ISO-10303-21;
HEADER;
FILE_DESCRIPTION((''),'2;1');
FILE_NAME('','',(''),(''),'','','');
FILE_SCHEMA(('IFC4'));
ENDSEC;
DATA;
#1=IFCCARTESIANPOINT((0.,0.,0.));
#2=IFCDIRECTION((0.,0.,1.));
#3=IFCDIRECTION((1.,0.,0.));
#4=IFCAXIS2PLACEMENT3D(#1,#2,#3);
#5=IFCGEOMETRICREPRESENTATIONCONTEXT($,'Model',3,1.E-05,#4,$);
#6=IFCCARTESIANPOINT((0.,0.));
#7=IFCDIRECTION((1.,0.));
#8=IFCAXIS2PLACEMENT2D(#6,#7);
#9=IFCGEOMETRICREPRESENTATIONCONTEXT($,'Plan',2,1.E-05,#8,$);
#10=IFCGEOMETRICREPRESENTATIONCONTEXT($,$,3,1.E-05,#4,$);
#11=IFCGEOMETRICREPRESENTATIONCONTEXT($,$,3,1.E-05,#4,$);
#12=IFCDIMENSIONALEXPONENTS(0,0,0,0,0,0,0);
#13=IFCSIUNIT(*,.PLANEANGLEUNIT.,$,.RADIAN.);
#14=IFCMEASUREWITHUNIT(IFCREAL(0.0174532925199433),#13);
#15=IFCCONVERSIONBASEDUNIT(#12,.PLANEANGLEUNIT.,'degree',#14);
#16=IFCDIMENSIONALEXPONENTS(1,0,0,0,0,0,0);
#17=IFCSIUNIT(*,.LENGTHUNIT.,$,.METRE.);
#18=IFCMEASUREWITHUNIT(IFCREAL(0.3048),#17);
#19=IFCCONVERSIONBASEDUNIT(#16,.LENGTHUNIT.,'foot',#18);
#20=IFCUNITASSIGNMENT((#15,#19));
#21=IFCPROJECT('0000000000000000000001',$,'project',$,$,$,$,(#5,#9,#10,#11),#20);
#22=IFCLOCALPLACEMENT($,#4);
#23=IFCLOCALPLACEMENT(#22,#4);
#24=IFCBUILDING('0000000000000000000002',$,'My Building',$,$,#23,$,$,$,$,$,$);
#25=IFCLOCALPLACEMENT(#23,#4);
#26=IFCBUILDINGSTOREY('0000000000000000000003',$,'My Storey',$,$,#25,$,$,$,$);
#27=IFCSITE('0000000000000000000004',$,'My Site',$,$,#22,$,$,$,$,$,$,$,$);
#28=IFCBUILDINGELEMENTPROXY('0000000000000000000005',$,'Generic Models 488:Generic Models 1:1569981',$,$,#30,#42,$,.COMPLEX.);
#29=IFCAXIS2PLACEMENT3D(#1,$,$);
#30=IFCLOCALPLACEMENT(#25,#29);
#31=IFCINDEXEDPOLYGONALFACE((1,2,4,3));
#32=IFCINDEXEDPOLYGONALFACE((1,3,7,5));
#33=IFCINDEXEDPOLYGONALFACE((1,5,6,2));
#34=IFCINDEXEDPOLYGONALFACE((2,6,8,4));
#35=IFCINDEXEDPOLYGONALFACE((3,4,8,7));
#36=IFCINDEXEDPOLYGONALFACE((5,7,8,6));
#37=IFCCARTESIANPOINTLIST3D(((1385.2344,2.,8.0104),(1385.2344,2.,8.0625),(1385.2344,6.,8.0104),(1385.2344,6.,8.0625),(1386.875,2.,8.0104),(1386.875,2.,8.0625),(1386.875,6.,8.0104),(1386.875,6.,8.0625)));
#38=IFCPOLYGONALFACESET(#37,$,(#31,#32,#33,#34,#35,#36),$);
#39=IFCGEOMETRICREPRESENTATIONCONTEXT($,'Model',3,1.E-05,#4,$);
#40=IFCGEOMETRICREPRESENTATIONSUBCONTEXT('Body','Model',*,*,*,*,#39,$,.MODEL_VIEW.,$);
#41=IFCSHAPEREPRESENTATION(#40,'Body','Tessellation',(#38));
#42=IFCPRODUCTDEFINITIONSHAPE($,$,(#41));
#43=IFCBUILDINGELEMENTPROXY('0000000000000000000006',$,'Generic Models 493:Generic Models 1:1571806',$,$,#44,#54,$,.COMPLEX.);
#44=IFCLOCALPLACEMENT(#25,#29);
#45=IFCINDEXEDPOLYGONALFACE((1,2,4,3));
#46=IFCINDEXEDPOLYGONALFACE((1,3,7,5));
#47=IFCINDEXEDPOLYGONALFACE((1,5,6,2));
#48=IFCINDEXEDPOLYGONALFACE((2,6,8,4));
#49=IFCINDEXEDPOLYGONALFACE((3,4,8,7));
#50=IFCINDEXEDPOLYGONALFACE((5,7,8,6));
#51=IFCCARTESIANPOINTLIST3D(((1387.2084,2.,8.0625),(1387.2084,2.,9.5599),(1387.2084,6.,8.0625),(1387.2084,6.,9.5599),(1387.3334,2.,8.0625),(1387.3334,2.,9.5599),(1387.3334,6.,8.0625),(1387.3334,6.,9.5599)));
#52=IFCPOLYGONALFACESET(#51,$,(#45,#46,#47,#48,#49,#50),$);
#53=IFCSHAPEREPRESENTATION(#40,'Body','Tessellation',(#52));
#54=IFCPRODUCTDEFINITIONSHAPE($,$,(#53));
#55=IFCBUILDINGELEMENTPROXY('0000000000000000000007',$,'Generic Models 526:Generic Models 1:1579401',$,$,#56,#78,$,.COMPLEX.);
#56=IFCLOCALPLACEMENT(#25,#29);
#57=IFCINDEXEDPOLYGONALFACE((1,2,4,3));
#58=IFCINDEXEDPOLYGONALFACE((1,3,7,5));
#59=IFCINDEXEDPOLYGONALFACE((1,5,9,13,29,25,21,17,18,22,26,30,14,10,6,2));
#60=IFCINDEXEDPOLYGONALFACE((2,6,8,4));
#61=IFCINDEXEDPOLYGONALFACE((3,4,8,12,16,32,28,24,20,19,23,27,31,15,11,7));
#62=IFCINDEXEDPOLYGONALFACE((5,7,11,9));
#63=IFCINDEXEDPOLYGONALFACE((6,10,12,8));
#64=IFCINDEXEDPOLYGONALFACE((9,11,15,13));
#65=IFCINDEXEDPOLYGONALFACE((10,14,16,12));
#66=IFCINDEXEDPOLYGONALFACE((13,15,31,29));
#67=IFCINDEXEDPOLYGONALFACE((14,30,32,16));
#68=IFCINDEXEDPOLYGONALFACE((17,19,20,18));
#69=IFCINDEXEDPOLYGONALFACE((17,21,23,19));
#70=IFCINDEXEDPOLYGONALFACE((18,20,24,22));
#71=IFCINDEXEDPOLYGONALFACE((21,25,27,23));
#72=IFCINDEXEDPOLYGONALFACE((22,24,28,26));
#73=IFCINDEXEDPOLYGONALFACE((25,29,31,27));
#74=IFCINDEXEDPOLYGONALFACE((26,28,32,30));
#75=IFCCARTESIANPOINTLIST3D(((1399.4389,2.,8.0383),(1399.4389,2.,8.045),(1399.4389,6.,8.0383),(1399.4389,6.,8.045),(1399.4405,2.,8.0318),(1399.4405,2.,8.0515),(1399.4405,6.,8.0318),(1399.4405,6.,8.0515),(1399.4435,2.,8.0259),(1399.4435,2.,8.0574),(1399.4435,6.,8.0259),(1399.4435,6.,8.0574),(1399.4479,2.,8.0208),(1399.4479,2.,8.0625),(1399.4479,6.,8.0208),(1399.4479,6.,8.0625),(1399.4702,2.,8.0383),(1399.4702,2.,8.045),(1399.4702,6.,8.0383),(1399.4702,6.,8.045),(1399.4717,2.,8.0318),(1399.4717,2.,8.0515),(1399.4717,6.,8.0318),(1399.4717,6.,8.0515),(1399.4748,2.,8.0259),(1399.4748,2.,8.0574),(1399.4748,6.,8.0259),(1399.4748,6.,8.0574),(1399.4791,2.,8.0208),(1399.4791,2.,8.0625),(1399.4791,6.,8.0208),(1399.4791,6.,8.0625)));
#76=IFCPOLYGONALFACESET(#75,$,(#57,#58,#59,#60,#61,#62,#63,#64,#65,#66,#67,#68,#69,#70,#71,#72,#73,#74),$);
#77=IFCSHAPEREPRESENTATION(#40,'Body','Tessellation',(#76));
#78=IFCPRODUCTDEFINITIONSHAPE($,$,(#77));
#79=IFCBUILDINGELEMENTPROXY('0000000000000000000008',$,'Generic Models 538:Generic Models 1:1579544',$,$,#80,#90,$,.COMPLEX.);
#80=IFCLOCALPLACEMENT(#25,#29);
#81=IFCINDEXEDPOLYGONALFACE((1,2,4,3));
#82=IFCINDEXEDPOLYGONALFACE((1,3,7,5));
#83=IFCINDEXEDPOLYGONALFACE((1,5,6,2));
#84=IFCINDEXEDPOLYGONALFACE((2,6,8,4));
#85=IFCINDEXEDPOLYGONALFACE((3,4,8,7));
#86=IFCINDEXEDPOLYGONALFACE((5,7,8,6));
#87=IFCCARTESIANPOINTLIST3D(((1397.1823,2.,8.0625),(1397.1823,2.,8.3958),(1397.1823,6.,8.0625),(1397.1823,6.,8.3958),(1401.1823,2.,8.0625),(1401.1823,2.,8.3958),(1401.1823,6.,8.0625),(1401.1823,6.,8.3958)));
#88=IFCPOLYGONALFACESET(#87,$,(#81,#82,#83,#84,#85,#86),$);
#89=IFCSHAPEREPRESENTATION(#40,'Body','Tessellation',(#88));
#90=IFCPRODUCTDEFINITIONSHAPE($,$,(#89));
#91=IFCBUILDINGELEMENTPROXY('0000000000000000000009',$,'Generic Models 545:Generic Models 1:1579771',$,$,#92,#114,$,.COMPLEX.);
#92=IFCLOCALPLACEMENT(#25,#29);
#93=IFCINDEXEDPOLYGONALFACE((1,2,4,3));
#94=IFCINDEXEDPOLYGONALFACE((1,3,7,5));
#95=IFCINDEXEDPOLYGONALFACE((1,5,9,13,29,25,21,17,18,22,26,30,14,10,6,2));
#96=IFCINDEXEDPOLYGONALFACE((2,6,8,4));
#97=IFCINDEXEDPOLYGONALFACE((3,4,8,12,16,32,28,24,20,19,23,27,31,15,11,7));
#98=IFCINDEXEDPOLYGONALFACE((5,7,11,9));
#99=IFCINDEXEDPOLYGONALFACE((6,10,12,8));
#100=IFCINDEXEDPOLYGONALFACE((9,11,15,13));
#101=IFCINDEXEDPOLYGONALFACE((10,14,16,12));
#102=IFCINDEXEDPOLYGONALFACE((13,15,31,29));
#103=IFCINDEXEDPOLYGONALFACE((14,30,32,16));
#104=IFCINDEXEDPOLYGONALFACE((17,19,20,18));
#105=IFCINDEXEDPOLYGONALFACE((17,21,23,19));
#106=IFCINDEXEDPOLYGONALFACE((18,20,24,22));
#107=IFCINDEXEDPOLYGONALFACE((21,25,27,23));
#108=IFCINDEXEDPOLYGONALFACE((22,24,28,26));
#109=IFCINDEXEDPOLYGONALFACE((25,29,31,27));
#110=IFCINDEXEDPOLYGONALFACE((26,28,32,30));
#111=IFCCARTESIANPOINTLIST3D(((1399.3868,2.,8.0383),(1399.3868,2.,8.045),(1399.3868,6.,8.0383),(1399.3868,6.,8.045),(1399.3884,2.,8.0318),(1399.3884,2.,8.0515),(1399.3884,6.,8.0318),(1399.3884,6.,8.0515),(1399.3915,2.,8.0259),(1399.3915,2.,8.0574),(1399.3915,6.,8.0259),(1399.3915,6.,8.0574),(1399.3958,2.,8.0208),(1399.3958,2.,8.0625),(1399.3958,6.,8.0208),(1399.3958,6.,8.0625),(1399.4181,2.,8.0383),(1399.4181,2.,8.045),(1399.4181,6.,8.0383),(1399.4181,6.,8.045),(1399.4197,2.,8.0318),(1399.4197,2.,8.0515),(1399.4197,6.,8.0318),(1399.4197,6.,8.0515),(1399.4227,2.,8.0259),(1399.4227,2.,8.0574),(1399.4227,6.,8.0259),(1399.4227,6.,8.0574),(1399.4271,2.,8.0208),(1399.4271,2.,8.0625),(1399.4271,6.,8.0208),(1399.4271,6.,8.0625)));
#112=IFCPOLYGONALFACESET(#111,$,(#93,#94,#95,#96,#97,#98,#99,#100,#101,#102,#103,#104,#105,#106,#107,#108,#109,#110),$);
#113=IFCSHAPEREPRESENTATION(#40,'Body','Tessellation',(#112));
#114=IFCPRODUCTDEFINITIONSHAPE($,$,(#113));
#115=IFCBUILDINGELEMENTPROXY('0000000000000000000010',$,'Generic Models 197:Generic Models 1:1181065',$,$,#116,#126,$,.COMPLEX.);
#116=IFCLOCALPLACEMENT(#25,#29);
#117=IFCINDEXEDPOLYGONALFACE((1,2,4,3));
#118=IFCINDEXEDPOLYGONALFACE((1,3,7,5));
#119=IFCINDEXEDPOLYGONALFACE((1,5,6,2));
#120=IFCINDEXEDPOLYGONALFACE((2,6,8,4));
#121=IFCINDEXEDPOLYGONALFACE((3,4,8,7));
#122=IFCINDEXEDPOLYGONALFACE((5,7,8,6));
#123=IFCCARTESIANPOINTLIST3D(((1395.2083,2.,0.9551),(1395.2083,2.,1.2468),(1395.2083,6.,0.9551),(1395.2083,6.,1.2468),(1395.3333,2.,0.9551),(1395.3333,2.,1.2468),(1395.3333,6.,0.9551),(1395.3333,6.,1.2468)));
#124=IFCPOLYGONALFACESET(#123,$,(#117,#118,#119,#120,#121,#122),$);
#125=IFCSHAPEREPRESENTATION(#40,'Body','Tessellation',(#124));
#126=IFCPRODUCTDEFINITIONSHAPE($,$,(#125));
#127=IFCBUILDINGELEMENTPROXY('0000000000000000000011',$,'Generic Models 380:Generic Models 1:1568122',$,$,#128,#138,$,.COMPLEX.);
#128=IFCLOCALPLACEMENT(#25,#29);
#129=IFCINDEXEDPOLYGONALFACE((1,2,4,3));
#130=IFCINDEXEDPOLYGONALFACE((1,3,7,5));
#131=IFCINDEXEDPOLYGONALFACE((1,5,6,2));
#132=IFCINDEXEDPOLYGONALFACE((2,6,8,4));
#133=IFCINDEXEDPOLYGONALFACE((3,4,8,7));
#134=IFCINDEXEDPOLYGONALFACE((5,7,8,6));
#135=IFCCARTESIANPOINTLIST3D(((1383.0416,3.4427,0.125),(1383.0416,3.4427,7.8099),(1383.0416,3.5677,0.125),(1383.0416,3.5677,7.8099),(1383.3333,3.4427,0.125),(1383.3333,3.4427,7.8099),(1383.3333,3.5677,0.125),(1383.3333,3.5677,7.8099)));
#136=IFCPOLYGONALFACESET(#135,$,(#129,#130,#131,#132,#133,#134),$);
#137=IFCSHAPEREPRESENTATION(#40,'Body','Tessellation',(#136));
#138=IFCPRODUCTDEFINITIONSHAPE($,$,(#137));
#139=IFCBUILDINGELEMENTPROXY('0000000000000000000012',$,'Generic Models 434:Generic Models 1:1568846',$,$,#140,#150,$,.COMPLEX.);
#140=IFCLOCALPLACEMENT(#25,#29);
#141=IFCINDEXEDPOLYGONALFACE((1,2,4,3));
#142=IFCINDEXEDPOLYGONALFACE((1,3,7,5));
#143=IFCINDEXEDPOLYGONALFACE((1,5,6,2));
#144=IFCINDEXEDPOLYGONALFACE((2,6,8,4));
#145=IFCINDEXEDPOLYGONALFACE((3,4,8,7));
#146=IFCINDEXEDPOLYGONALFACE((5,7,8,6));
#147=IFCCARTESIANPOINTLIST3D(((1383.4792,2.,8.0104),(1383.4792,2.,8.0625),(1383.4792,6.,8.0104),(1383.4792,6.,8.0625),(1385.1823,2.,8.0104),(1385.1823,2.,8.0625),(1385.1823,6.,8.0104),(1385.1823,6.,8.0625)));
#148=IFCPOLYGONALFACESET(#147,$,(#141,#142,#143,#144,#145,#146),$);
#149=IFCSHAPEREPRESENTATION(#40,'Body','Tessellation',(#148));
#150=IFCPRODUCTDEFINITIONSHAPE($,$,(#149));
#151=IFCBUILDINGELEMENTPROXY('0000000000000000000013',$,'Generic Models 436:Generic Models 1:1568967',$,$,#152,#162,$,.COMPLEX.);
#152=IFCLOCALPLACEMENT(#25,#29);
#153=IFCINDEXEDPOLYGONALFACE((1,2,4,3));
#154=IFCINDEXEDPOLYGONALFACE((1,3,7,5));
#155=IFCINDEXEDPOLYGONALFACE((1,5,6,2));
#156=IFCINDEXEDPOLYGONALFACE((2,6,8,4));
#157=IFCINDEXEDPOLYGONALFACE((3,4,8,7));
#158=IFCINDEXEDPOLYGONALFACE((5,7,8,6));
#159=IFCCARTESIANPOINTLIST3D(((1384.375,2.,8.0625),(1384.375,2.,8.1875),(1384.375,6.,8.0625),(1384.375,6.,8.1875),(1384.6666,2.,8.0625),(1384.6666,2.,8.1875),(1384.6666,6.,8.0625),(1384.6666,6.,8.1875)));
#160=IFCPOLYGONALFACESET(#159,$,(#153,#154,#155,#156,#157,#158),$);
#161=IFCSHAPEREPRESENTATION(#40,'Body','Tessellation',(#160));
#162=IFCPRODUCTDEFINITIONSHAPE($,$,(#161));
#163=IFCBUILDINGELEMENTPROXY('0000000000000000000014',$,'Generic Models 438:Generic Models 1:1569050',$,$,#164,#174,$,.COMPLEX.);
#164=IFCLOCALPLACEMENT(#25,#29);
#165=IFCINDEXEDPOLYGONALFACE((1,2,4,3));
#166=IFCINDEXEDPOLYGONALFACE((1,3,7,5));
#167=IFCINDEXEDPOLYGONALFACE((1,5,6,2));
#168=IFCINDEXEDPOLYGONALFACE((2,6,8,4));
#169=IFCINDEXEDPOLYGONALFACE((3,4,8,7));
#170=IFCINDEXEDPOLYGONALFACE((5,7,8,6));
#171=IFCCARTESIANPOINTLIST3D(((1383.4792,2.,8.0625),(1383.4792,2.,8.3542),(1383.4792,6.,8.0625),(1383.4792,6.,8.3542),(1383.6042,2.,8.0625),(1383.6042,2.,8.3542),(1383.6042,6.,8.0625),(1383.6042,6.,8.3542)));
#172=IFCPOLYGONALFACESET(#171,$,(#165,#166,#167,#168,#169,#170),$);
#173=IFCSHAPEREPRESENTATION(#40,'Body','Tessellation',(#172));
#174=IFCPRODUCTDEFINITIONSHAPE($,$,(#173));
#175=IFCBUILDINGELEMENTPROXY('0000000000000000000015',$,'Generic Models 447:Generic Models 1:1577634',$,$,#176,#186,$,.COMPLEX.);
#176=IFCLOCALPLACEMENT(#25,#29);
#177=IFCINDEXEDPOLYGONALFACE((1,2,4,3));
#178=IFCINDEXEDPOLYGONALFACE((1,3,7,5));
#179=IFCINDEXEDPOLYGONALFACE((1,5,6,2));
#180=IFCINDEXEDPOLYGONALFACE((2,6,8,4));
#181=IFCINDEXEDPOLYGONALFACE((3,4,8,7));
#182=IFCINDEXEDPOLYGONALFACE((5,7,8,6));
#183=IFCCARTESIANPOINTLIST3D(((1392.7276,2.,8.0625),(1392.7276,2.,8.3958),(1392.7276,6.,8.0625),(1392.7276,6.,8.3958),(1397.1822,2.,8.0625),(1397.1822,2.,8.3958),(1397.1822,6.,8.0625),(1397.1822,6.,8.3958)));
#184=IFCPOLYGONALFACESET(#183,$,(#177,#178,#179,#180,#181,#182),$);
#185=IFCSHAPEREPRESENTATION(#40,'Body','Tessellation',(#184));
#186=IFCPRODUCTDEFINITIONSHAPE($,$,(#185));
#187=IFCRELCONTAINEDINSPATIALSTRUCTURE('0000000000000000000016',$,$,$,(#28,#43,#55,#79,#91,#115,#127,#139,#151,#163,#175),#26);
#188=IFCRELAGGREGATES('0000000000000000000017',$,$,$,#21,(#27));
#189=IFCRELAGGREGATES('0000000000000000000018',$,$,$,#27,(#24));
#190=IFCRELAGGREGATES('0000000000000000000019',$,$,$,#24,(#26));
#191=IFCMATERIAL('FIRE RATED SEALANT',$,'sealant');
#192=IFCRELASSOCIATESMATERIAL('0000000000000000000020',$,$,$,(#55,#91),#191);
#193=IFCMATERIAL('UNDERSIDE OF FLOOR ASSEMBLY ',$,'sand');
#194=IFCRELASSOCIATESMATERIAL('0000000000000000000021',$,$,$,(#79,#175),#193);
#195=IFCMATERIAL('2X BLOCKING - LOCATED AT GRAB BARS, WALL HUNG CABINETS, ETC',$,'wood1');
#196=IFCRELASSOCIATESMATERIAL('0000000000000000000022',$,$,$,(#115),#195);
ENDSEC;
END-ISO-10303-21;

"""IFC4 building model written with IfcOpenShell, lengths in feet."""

from ifc_helpers import new_model, entity, si_unit, converted_unit, frame, origin_with_axes, origin_2d_with_axis, place, context, subcontext, project, spatial, polyline, line, indexed_curve, outline, extrude, material, element, save


model = new_model("IFC4")

# Units and contexts
model_context_1 = context("Model", 3, precision=1e-05, world=origin_with_axes())
plan_context = context("Plan", 2, precision=1e-05, world=origin_2d_with_axis())
model_context_2 = context("Model", 3, precision=1e-05, world=origin_with_axes())
context_of_model_1 = context(None, 3, precision=1e-05, world=origin_with_axes())
context_of_model_2 = context(None, 3, precision=1e-05, world=origin_with_axes())
body_context = subcontext(model_context_2, "Body", "Model", "MODEL_VIEW")
ifc_project = project(units=[converted_unit("PLANEANGLEUNIT", "degree", entity("IfcReal", 0.0174532925199433), si_unit("PLANEANGLEUNIT", "RADIAN"), dimensions=[0, 0, 0, 0, 0, 0, 0]), converted_unit("LENGTHUNIT", "foot", entity("IfcReal", 0.3048), si_unit("LENGTHUNIT", "METRE"), dimensions=[1, 0, 0, 0, 0, 0, 0])], contexts=[model_context_1, plan_context, context_of_model_1, context_of_model_2])

# Site, building, storey
site_placement = place(None, origin_with_axes())
site = spatial("IfcSite", under=ifc_project, at=site_placement, Name="My Site")
building_placement = place(site_placement, origin_with_axes())
building = spatial("IfcBuilding", under=site, at=building_placement, Name="My Building")
storey_placement = place(building_placement, origin_with_axes())
storey = spatial("IfcBuildingStorey", under=building, at=storey_placement, Name="My Storey")

# Building element proxies
proxy_1_placement = place(storey_placement, frame((1385.2344, 6.0, 8.0104), z_axis=(0.0, -1.0, 0.0), x_axis=(0.0, 0.0, 1.0)))
element("IfcBuildingElementProxy", 1, at=proxy_1_placement, inside=storey, Name="Generic Models 488:Generic Models 1:1569981", PredefinedType="COMPLEX", context=body_context, shape_type="SweptSolid", body=[
    extrude(outline(polyline([(-0.026, -0.8203), (0.026, -0.8203), (0.026, 0.8203), (-0.026, 0.8203), (-0.026, -0.8203)])), frame((0.026, -0.8203, 0.0), z_axis=(0.0, 0.0, -1.0), x_axis=(1.0, 0.0, 0.0)), (0.0, 0.0, -1.0), 4.0),
])
proxy_2_placement = place(storey_placement, frame((1387.2084, 6.0, 8.0625), z_axis=(0.0, -1.0, 0.0), x_axis=(0.0, 0.0, 1.0)))
element("IfcBuildingElementProxy", 2, at=proxy_2_placement, inside=storey, Name="Generic Models 493:Generic Models 1:1571806", PredefinedType="COMPLEX", context=body_context, shape_type="SweptSolid", body=[
    extrude(outline(polyline([(-0.7487, -0.0625), (0.7487, -0.0625), (0.7487, 0.0625), (-0.7487, 0.0625), (-0.7487, -0.0625)])), frame((0.7487, -0.0625, 0.0), z_axis=(0.0, 0.0, -1.0), x_axis=(-1.0, 0.0, 0.0)), (0.0, 0.0, -1.0), 4.0),
])
ifc_material_1 = material(Name="FIRE RATED SEALANT", Category="sealant")
proxy_3_placement = place(storey_placement, frame((1399.4389, 6.0, 8.0208), z_axis=(0.0, -1.0, 0.0), x_axis=(0.0, 0.0, 1.0)))
element("IfcBuildingElementProxy", 3, at=proxy_3_placement, inside=storey, material=ifc_material_1, Name="Generic Models 526:Generic Models 1:1579401", PredefinedType="COMPLEX", context=body_context, shape_type="SweptSolid", body=[
    extrude(outline(polyline([(0.0294, 0.0), (0.0074, 0.0221), (0.0007, 0.0216), (-0.0057, 0.0196), (-0.0114, 0.0161), (-0.0161, 0.0114), (-0.0196, 0.0057), (-0.0216, -0.0007), (-0.0221, -0.0073), (0.0, -0.0294), (0.0005, -0.0228), (0.0025, -0.0164), (0.006, -0.0107), (0.0107, -0.006), (0.0164, -0.0025), (0.0228, -0.0005), (0.0294, 0.0)])), frame((0.0208, -0.0194, 0.0), z_axis=(0.0, 0.0, -1.0), x_axis=(-0.707667, -0.706546, 0.0)), (0.0, 0.0, -1.0), 4.0),
])
ifc_material_2 = material(Name="UNDERSIDE OF FLOOR ASSEMBLY ", Category="sand")
proxy_4_placement = place(storey_placement, frame((1397.1823, 6.0, 8.0625), z_axis=(0.0, -1.0, 0.0), x_axis=(0.0, 0.0, 1.0)))
element("IfcBuildingElementProxy", 4, at=proxy_4_placement, inside=storey, material=ifc_material_2, Name="Generic Models 538:Generic Models 1:1579544", PredefinedType="COMPLEX", context=body_context, shape_type="SweptSolid", body=[
    extrude(outline(polyline([(-0.1667, -2.0), (0.1667, -2.0), (0.1667, 2.0), (-0.1667, 2.0), (-0.1667, -2.0)])), frame((0.1667, -2.0, 0.0), z_axis=(0.0, 0.0, -1.0), x_axis=(1.0, 0.0, 0.0)), (0.0, 0.0, -1.0), 4.0),
])
proxy_5_placement = place(storey_placement, frame((1399.3868, 6.0, 8.0208), z_axis=(0.0, -1.0, 0.0), x_axis=(0.0, 0.0, 1.0)))
element("IfcBuildingElementProxy", 5, at=proxy_5_placement, inside=storey, material=ifc_material_1, Name="Generic Models 545:Generic Models 1:1579771", PredefinedType="COMPLEX", context=body_context, shape_type="SweptSolid", body=[
    extrude(outline(polyline([(0.0166, 0.0), (0.0115, 0.0043), (0.0076, 0.0097), (0.005, 0.0159), (0.0039, 0.0224), (0.0045, 0.0291), (-0.0207, 0.0106), (-0.0213, 0.004), (-0.0202, -0.0026), (-0.0176, -0.0088), (-0.0137, -0.0142), (-0.0086, -0.0185), (-0.0026, -0.0215), (0.0039, -0.023), (0.0291, -0.0045), (0.0226, -0.003), (0.0166, 0.0)])), frame((0.0208, -0.0194, 0.0), z_axis=(0.0, 0.0, -1.0), x_axis=(0.591192, -0.806531, 0.0)), (0.0, 0.0, -1.0), 4.0),
])
ifc_material_3 = material(Name="2X BLOCKING - LOCATED AT GRAB BARS, WALL HUNG CABINETS, ETC", Category="wood1")
proxy_6_placement = place(storey_placement, frame((1395.2083, 6.0, 0.9551), z_axis=(0.0, -1.0, 0.0), x_axis=(0.0, 0.0, 1.0)))
element("IfcBuildingElementProxy", 6, at=proxy_6_placement, inside=storey, material=ifc_material_3, Name="Generic Models 197:Generic Models 1:1181065", PredefinedType="COMPLEX", context=body_context, shape_type="SweptSolid", body=[
    extrude(outline(polyline([(-0.0625, -0.1458), (0.0625, -0.1458), (0.0625, 0.1458), (-0.0625, 0.1458), (-0.0625, -0.1458)])), frame((0.1458, -0.0625, 0.0), z_axis=(0.0, 0.0, -1.0), x_axis=(0.0, -1.0, 0.0)), (0.0, 0.0, -1.0), 4.0),
])
proxy_7_placement = place(storey_placement, frame((1383.0416, 7.4427, 0.125), z_axis=(0.0, -1.0, 0.0), x_axis=(1.0, 0.0, 0.0)))
element("IfcBuildingElementProxy", 7, at=proxy_7_placement, inside=storey, Name="Generic Models 380:Generic Models 1:1568122", PredefinedType="COMPLEX", context=body_context, shape_type="SweptSolid", body=[
    extrude(outline(polyline([(-0.1458, -3.8424), (0.1458, -3.8424), (0.1458, 3.8424), (-0.1458, 3.8424), (-0.1458, -3.8424)])), frame((0.1458, 3.8424, 3.875), z_axis=(0.0, 0.0, -1.0), x_axis=(-1.0, 0.0, 0.0)), (0.0, 0.000002, -1.0), 0.125),
])
proxy_8_placement = place(storey_placement, frame((1383.4792, 6.0, 8.0104), z_axis=(0.0, -1.0, 0.0), x_axis=(0.0, 0.0, 1.0)))
element("IfcBuildingElementProxy", 8, at=proxy_8_placement, inside=storey, Name="Generic Models 434:Generic Models 1:1568846", PredefinedType="COMPLEX", context=body_context, shape_type="SweptSolid", body=[
    extrude(outline(polyline([(-0.026, -0.8516), (0.026, -0.8516), (0.026, 0.8516), (-0.026, 0.8516), (-0.026, -0.8516)])), frame((0.026, -0.8516, 0.0), z_axis=(0.0, 0.0, -1.0), x_axis=(-1.0, 0.0, 0.0)), (0.0, 0.0, -1.0), 4.0),
])
proxy_9_placement = place(storey_placement, frame((1384.375, 6.0, 8.0625), z_axis=(0.0, -1.0, 0.0), x_axis=(0.0, 0.0, 1.0)))
element("IfcBuildingElementProxy", 9, at=proxy_9_placement, inside=storey, Name="Generic Models 436:Generic Models 1:1568967", PredefinedType="COMPLEX", context=body_context, shape_type="SweptSolid", body=[
    extrude(outline(polyline([(-0.0625, -0.1458), (0.0625, -0.1458), (0.0625, 0.1458), (-0.0625, 0.1458), (-0.0625, -0.1458)])), frame((0.0625, -0.1458, 0.0), z_axis=(0.0, 0.0, -1.0), x_axis=(-1.0, 0.0, 0.0)), (0.0, 0.0, -1.0), 4.0),
])
proxy_10_placement = place(storey_placement, frame((1383.4792, 6.0, 8.0625), z_axis=(0.0, -1.0, 0.0), x_axis=(0.0, 0.0, 1.0)))
element("IfcBuildingElementProxy", 10, at=proxy_10_placement, inside=storey, Name="Generic Models 438:Generic Models 1:1569050", PredefinedType="COMPLEX", context=body_context, shape_type="SweptSolid", body=[
    extrude(outline(polyline([(-0.1458, -0.0625), (0.1458, -0.0625), (0.1458, 0.0625), (-0.1458, 0.0625), (-0.1458, -0.0625)])), frame((0.1458, -0.0625, 0.0), z_axis=(0.0, 0.0, -1.0), x_axis=(-1.0, 0.0, 0.0)), (0.0, 0.0, -1.0), 4.0),
])
proxy_11_placement = place(storey_placement, frame((1392.7276, 6.0, 8.0625), z_axis=(0.0, -1.0, 0.0), x_axis=(0.0, 0.0, 1.0)))
element("IfcBuildingElementProxy", 11, at=proxy_11_placement, inside=storey, material=ifc_material_2, Name="Generic Models 447:Generic Models 1:1577634", PredefinedType="COMPLEX", context=body_context, shape_type="SweptSolid", body=[
    extrude(outline(indexed_curve([(-2.4546, -0.1667), (2.0, -0.1667), (2.0, 0.1667), (-2.4546, 0.1667)], segments=[line(3, 2), line(2, 1), line(1, 4), line(4, 3)], self_intersect=False)), frame((0.1667, -2.0, 0.0), z_axis=(0.0, 0.0, -1.0), x_axis=(0.0, 1.0, 0.0)), (0.0, 0.0, -1.0), 4.0),
])

save(model, "model.ifc")
